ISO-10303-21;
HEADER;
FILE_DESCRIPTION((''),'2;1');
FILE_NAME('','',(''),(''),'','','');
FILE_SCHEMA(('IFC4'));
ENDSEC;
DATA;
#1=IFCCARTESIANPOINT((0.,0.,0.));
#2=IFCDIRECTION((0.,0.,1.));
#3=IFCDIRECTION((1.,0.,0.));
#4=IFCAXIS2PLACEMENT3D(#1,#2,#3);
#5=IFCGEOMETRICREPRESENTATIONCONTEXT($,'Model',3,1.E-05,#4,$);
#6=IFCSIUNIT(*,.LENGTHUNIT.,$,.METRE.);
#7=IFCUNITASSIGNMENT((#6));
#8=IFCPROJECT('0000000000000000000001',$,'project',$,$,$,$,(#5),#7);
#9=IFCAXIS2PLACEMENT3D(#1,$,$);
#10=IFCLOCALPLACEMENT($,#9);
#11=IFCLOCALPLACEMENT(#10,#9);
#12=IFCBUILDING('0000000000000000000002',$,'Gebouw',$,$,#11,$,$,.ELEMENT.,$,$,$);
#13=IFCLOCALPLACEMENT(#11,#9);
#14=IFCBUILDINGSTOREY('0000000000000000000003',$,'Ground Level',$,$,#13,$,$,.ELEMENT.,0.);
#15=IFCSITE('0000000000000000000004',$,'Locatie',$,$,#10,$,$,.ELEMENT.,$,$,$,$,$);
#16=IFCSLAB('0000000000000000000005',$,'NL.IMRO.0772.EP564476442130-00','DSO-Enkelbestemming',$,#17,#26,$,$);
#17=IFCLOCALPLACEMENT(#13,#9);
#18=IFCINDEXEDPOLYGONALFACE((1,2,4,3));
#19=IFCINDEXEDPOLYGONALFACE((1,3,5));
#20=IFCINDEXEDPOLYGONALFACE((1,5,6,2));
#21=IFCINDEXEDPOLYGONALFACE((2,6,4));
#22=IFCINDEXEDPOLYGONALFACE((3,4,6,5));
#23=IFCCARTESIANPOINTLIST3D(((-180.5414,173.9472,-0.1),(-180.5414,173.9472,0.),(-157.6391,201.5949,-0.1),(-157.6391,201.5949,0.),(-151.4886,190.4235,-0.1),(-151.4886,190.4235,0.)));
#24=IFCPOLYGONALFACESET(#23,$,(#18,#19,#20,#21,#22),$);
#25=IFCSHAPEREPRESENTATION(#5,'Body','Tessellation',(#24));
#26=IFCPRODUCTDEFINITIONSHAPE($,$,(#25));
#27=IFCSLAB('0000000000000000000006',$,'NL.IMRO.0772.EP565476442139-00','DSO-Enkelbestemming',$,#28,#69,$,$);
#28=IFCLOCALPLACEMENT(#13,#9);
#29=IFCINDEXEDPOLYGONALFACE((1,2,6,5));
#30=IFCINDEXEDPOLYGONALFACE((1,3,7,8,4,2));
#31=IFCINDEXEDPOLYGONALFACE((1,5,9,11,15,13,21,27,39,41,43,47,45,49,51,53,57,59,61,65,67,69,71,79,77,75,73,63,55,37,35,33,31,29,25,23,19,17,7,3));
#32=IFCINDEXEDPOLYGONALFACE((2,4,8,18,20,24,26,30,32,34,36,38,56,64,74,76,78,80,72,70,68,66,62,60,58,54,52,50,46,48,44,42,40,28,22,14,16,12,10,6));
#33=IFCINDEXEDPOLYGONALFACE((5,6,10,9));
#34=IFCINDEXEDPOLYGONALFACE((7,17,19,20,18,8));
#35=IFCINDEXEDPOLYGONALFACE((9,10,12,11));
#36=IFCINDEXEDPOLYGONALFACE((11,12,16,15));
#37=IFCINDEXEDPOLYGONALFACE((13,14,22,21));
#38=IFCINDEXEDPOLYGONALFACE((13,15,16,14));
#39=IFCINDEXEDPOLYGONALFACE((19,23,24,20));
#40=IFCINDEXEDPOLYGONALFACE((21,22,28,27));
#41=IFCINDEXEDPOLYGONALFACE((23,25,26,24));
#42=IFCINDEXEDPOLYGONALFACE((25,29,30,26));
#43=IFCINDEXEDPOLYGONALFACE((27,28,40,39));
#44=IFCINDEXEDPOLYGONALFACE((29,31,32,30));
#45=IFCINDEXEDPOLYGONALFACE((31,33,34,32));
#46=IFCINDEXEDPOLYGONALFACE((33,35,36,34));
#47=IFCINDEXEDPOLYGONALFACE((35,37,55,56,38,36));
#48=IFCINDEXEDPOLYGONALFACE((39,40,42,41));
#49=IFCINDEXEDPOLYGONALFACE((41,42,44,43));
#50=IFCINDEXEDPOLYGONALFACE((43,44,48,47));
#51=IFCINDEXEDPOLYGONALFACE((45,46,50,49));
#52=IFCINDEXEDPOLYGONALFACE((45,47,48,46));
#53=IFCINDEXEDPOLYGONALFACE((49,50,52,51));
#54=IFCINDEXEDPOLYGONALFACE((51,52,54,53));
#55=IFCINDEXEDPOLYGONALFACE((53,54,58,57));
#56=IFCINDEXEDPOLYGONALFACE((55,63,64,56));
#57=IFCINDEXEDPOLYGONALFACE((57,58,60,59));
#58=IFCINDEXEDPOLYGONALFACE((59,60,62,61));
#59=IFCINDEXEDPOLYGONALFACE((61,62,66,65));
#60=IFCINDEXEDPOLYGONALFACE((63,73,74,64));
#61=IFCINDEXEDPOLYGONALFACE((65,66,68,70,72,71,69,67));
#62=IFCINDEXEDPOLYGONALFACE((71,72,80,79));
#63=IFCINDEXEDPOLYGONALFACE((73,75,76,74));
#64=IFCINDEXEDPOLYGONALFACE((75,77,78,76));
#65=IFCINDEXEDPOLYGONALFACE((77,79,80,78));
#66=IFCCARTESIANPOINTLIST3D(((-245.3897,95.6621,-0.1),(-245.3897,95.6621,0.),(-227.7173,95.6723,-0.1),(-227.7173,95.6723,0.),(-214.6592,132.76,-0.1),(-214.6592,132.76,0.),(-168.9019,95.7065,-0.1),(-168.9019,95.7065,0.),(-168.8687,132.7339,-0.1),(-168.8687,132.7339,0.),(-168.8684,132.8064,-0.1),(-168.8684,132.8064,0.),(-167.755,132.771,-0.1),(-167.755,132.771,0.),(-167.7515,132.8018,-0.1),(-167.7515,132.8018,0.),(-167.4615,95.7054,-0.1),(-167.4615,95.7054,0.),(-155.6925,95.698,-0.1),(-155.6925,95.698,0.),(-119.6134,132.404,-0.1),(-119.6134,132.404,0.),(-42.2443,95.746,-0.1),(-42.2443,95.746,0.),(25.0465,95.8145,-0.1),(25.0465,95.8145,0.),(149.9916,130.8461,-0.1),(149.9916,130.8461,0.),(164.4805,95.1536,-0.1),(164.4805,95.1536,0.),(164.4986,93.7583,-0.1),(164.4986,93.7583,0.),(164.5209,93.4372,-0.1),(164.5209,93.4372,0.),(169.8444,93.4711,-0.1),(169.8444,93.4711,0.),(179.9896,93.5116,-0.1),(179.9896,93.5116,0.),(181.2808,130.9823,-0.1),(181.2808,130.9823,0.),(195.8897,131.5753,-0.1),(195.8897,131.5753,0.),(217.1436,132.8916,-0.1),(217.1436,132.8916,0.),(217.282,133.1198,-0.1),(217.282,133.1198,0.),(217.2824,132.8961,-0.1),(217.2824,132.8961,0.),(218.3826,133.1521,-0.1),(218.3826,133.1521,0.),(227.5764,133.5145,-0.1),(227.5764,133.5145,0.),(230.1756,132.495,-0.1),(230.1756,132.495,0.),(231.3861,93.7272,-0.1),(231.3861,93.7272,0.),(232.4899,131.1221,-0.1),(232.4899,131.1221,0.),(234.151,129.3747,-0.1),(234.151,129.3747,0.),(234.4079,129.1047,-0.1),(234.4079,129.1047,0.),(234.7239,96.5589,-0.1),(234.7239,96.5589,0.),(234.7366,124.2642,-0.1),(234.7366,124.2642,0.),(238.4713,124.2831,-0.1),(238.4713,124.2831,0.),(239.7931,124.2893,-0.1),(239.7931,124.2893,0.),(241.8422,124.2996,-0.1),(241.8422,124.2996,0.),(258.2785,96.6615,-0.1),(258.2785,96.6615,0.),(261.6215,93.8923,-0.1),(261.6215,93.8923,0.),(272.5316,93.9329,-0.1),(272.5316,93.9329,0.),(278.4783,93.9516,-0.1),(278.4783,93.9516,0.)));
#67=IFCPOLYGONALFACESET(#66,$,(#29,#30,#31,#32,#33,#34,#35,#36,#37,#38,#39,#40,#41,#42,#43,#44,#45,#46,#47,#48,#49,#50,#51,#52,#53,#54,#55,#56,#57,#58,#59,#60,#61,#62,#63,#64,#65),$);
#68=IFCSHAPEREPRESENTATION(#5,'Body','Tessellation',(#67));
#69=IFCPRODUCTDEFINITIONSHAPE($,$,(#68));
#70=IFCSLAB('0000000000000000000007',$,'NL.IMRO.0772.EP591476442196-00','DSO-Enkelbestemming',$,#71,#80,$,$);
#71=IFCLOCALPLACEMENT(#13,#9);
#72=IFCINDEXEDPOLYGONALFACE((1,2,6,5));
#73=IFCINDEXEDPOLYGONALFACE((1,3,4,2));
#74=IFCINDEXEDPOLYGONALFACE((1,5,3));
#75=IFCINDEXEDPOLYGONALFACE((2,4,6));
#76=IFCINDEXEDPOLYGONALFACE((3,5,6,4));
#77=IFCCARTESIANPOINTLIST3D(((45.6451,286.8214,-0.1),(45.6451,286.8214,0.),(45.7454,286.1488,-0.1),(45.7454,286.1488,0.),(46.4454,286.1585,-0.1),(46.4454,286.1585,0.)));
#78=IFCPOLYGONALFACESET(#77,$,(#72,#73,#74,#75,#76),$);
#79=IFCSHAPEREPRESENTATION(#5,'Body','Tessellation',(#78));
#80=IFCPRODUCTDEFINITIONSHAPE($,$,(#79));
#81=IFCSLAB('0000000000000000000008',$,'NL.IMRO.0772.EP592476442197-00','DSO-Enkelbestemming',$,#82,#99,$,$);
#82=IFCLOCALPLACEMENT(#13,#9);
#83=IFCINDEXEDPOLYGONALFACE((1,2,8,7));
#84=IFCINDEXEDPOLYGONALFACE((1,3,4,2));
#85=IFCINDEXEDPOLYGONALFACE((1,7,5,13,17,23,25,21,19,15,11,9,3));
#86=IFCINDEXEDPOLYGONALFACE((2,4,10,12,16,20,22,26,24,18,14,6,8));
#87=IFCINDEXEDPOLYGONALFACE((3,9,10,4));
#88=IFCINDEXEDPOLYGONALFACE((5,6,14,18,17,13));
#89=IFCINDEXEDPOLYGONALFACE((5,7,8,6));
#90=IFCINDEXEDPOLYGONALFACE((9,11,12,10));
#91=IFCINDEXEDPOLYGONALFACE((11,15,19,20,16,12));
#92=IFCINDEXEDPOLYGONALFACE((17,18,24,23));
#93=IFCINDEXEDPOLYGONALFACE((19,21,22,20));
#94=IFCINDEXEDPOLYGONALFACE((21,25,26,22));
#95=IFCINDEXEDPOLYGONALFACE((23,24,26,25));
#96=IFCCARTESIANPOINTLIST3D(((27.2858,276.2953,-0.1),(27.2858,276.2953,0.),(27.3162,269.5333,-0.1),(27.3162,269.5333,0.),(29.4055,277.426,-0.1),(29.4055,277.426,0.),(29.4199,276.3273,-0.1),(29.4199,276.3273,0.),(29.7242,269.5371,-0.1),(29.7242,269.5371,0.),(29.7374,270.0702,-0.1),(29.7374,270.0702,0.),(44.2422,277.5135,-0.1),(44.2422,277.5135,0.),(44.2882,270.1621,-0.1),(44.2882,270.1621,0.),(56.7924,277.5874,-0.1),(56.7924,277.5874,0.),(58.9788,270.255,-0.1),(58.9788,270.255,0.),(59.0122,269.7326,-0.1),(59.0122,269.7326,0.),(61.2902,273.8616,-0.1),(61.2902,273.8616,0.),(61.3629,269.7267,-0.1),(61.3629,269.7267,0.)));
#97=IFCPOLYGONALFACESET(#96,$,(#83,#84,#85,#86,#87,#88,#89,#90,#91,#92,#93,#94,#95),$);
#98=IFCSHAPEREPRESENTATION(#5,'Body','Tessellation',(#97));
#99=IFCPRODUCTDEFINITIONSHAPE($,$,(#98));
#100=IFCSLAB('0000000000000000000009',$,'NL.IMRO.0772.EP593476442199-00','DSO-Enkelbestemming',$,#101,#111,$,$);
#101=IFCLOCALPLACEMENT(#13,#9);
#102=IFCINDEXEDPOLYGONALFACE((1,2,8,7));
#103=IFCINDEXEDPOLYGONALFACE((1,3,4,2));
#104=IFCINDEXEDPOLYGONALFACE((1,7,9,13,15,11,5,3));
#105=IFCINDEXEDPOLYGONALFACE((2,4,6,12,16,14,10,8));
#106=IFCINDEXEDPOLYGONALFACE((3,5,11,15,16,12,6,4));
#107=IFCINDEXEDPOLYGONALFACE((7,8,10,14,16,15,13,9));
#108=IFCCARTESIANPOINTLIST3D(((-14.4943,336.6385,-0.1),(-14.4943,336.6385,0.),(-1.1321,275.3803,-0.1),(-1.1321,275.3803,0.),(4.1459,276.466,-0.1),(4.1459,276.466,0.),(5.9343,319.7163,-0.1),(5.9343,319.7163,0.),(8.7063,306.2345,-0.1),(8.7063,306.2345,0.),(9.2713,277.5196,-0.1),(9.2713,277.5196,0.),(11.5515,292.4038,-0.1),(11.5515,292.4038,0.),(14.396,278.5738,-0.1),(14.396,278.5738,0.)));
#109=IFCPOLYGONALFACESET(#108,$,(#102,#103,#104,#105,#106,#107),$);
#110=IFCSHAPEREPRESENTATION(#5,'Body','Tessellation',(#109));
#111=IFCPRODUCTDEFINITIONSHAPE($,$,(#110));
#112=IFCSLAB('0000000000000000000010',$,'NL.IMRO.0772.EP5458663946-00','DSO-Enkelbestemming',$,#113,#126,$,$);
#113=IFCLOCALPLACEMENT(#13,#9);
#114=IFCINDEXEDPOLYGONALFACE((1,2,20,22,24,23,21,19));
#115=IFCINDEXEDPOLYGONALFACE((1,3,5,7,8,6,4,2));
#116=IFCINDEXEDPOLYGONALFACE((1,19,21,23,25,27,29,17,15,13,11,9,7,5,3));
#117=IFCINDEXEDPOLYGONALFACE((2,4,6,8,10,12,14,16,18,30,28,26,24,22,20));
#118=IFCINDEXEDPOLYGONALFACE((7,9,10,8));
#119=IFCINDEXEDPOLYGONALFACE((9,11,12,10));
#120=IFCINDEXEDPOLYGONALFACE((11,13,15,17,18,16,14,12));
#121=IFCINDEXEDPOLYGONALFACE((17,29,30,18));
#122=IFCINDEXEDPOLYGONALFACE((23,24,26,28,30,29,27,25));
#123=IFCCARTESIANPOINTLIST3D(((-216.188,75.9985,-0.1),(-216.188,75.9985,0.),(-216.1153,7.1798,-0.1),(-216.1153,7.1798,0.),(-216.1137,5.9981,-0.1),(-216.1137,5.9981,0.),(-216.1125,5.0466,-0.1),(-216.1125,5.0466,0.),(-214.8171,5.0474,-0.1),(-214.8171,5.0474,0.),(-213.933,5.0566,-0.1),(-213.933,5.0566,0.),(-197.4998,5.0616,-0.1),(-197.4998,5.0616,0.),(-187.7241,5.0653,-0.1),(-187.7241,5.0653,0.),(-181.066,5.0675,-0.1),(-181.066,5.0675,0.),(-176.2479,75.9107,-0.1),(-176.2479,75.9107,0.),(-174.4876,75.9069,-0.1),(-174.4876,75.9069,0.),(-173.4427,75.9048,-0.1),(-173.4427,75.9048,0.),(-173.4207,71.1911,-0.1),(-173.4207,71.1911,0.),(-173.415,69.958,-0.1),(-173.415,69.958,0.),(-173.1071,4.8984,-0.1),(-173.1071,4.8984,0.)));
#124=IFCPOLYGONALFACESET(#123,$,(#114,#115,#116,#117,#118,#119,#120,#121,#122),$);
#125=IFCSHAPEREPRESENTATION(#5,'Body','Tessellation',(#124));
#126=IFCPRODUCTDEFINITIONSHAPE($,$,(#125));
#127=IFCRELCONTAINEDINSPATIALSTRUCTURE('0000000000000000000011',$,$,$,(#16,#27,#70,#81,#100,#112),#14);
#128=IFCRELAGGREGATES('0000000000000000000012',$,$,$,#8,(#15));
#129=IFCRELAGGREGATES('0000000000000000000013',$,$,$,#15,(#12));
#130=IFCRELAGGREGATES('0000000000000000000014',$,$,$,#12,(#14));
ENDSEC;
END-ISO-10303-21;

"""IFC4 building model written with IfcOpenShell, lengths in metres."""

from ifc_helpers import new_model, si_unit, frame, origin, origin_with_axes, place, context, project, spatial, polyline, outline, extrude, element, save


model = new_model("IFC4")

# Units and contexts
model_context = context("Model", 3, precision=1e-05, world=origin_with_axes())
ifc_project = project(units=[si_unit("LENGTHUNIT", "METRE")], contexts=[model_context])

# Site, building, storey
site_placement = place(None, origin())
site = spatial("IfcSite", under=ifc_project, at=site_placement, Name="Locatie", CompositionType="ELEMENT")
building_placement = place(site_placement, origin())
building = spatial("IfcBuilding", under=site, at=building_placement, Name="Gebouw", CompositionType="ELEMENT")
storey_placement = place(building_placement, origin())
storey = spatial("IfcBuildingStorey", under=building, at=storey_placement, Name="Ground Level", CompositionType="ELEMENT", Elevation=0.0)

# Slabs
slab_1_placement = place(storey_placement, origin())
element("IfcSlab", 1, at=slab_1_placement, inside=storey, Name="NL.IMRO.0772.EP564476442130-00", Description="DSO-Enkelbestemming", context=model_context, shape_type="SweptSolid", body=[
    extrude(outline(polyline([(-151.4886, 190.4235), (-180.5414, 173.9472), (-157.6391, 201.5949), (-151.4886, 190.4235)])), frame((0.0, 0.0, -0.1), z_axis=(0.0, 0.0, 1.0), x_axis=(1.0, 0.0, 0.0)), (0.0, 0.0, 1.0), 0.1),
])
slab_2_placement = place(storey_placement, origin())
element("IfcSlab", 2, at=slab_2_placement, inside=storey, Name="NL.IMRO.0772.EP565476442139-00", Description="DSO-Enkelbestemming", context=model_context, shape_type="SweptSolid", body=[
    extrude(outline(polyline([(-168.8687, 132.7339), (-168.8684, 132.8064), (-167.7515, 132.8018), (-167.755, 132.771), (-119.6134, 132.404), (149.9916, 130.8461), (181.2808, 130.9823), (195.8897, 131.5753), (217.1436, 132.8916), (217.2824, 132.8961), (217.282, 133.1198), (218.3826, 133.1521), (227.5764, 133.5145), (230.1756, 132.495), (232.4899, 131.1221), (234.151, 129.3747), (234.4079, 129.1047), (234.7366, 124.2642), (238.4713, 124.2831), (239.7931, 124.2893), (241.8422, 124.2996), (278.4783, 93.9516), (272.5316, 93.9329), (261.6215, 93.8923), (258.2785, 96.6615), (234.7239, 96.5589), (231.3861, 93.7272), (179.9896, 93.5116), (169.8444, 93.4711), (164.5209, 93.4372), (164.4986, 93.7583), (164.4805, 95.1536), (25.0465, 95.8145), (-42.2443, 95.746), (-155.6925, 95.698), (-167.4615, 95.7054), (-168.9019, 95.7065), (-227.7173, 95.6723), (-245.3897, 95.6621), (-214.6592, 132.76), (-168.8687, 132.7339)])), frame((0.0, 0.0, -0.1), z_axis=(0.0, 0.0, 1.0), x_axis=(1.0, 0.0, 0.0)), (0.0, 0.0, 1.0), 0.1),
])
slab_3_placement = place(storey_placement, origin())
element("IfcSlab", 3, at=slab_3_placement, inside=storey, Name="NL.IMRO.0772.EP591476442196-00", Description="DSO-Enkelbestemming", context=model_context, shape_type="SweptSolid", body=[
    extrude(outline(polyline([(45.7454, 286.1488), (45.6451, 286.8214), (46.4454, 286.1585), (45.7454, 286.1488)])), frame((0.0, 0.0, -0.1), z_axis=(0.0, 0.0, 1.0), x_axis=(1.0, 0.0, 0.0)), (0.0, 0.0, 1.0), 0.1),
])
slab_4_placement = place(storey_placement, origin())
element("IfcSlab", 4, at=slab_4_placement, inside=storey, Name="NL.IMRO.0772.EP592476442197-00", Description="DSO-Enkelbestemming", context=model_context, shape_type="SweptSolid", body=[
    extrude(outline(polyline([(61.3629, 269.7267), (59.0122, 269.7326), (58.9788, 270.255), (44.2882, 270.1621), (29.7374, 270.0702), (29.7242, 269.5371), (27.3162, 269.5333), (27.2858, 276.2953), (29.4199, 276.3273), (29.4055, 277.426), (44.2422, 277.5135), (56.7924, 277.5874), (61.2902, 273.8616), (61.3629, 269.7267)])), frame((0.0, 0.0, -0.1), z_axis=(0.0, 0.0, 1.0), x_axis=(1.0, 0.0, 0.0)), (0.0, 0.0, 1.0), 0.1),
])
slab_5_placement = place(storey_placement, origin())
element("IfcSlab", 5, at=slab_5_placement, inside=storey, Name="NL.IMRO.0772.EP593476442199-00", Description="DSO-Enkelbestemming", context=model_context, shape_type="SweptSolid", body=[
    extrude(outline(polyline([(8.7063, 306.2345), (11.5515, 292.4038), (14.396, 278.5738), (9.2713, 277.5196), (4.1459, 276.466), (-1.1321, 275.3803), (-14.4943, 336.6385), (5.9343, 319.7163), (8.7063, 306.2345)])), frame((0.0, 0.0, -0.1), z_axis=(0.0, 0.0, 1.0), x_axis=(1.0, 0.0, 0.0)), (0.0, 0.0, 1.0), 0.1),
])
slab_6_placement = place(storey_placement, origin())
element("IfcSlab", 6, at=slab_6_placement, inside=storey, Name="NL.IMRO.0772.EP5458663946-00", Description="DSO-Enkelbestemming", context=model_context, shape_type="SweptSolid", body=[
    extrude(outline(polyline([(-213.933, 5.0566), (-214.8171, 5.0474), (-216.1125, 5.0466), (-216.1137, 5.9981), (-216.1153, 7.1798), (-216.188, 75.9985), (-176.2479, 75.9107), (-174.4876, 75.9069), (-173.4427, 75.9048), (-173.4207, 71.1911), (-173.415, 69.958), (-173.1071, 4.8984), (-181.066, 5.0675), (-187.7241, 5.0653), (-197.4998, 5.0616), (-213.933, 5.0566)])), frame((0.0, 0.0, -0.1), z_axis=(0.0, 0.0, 1.0), x_axis=(1.0, 0.0, 0.0)), (0.0, 0.0, 1.0), 0.1),
])

save(model, "model.ifc")
